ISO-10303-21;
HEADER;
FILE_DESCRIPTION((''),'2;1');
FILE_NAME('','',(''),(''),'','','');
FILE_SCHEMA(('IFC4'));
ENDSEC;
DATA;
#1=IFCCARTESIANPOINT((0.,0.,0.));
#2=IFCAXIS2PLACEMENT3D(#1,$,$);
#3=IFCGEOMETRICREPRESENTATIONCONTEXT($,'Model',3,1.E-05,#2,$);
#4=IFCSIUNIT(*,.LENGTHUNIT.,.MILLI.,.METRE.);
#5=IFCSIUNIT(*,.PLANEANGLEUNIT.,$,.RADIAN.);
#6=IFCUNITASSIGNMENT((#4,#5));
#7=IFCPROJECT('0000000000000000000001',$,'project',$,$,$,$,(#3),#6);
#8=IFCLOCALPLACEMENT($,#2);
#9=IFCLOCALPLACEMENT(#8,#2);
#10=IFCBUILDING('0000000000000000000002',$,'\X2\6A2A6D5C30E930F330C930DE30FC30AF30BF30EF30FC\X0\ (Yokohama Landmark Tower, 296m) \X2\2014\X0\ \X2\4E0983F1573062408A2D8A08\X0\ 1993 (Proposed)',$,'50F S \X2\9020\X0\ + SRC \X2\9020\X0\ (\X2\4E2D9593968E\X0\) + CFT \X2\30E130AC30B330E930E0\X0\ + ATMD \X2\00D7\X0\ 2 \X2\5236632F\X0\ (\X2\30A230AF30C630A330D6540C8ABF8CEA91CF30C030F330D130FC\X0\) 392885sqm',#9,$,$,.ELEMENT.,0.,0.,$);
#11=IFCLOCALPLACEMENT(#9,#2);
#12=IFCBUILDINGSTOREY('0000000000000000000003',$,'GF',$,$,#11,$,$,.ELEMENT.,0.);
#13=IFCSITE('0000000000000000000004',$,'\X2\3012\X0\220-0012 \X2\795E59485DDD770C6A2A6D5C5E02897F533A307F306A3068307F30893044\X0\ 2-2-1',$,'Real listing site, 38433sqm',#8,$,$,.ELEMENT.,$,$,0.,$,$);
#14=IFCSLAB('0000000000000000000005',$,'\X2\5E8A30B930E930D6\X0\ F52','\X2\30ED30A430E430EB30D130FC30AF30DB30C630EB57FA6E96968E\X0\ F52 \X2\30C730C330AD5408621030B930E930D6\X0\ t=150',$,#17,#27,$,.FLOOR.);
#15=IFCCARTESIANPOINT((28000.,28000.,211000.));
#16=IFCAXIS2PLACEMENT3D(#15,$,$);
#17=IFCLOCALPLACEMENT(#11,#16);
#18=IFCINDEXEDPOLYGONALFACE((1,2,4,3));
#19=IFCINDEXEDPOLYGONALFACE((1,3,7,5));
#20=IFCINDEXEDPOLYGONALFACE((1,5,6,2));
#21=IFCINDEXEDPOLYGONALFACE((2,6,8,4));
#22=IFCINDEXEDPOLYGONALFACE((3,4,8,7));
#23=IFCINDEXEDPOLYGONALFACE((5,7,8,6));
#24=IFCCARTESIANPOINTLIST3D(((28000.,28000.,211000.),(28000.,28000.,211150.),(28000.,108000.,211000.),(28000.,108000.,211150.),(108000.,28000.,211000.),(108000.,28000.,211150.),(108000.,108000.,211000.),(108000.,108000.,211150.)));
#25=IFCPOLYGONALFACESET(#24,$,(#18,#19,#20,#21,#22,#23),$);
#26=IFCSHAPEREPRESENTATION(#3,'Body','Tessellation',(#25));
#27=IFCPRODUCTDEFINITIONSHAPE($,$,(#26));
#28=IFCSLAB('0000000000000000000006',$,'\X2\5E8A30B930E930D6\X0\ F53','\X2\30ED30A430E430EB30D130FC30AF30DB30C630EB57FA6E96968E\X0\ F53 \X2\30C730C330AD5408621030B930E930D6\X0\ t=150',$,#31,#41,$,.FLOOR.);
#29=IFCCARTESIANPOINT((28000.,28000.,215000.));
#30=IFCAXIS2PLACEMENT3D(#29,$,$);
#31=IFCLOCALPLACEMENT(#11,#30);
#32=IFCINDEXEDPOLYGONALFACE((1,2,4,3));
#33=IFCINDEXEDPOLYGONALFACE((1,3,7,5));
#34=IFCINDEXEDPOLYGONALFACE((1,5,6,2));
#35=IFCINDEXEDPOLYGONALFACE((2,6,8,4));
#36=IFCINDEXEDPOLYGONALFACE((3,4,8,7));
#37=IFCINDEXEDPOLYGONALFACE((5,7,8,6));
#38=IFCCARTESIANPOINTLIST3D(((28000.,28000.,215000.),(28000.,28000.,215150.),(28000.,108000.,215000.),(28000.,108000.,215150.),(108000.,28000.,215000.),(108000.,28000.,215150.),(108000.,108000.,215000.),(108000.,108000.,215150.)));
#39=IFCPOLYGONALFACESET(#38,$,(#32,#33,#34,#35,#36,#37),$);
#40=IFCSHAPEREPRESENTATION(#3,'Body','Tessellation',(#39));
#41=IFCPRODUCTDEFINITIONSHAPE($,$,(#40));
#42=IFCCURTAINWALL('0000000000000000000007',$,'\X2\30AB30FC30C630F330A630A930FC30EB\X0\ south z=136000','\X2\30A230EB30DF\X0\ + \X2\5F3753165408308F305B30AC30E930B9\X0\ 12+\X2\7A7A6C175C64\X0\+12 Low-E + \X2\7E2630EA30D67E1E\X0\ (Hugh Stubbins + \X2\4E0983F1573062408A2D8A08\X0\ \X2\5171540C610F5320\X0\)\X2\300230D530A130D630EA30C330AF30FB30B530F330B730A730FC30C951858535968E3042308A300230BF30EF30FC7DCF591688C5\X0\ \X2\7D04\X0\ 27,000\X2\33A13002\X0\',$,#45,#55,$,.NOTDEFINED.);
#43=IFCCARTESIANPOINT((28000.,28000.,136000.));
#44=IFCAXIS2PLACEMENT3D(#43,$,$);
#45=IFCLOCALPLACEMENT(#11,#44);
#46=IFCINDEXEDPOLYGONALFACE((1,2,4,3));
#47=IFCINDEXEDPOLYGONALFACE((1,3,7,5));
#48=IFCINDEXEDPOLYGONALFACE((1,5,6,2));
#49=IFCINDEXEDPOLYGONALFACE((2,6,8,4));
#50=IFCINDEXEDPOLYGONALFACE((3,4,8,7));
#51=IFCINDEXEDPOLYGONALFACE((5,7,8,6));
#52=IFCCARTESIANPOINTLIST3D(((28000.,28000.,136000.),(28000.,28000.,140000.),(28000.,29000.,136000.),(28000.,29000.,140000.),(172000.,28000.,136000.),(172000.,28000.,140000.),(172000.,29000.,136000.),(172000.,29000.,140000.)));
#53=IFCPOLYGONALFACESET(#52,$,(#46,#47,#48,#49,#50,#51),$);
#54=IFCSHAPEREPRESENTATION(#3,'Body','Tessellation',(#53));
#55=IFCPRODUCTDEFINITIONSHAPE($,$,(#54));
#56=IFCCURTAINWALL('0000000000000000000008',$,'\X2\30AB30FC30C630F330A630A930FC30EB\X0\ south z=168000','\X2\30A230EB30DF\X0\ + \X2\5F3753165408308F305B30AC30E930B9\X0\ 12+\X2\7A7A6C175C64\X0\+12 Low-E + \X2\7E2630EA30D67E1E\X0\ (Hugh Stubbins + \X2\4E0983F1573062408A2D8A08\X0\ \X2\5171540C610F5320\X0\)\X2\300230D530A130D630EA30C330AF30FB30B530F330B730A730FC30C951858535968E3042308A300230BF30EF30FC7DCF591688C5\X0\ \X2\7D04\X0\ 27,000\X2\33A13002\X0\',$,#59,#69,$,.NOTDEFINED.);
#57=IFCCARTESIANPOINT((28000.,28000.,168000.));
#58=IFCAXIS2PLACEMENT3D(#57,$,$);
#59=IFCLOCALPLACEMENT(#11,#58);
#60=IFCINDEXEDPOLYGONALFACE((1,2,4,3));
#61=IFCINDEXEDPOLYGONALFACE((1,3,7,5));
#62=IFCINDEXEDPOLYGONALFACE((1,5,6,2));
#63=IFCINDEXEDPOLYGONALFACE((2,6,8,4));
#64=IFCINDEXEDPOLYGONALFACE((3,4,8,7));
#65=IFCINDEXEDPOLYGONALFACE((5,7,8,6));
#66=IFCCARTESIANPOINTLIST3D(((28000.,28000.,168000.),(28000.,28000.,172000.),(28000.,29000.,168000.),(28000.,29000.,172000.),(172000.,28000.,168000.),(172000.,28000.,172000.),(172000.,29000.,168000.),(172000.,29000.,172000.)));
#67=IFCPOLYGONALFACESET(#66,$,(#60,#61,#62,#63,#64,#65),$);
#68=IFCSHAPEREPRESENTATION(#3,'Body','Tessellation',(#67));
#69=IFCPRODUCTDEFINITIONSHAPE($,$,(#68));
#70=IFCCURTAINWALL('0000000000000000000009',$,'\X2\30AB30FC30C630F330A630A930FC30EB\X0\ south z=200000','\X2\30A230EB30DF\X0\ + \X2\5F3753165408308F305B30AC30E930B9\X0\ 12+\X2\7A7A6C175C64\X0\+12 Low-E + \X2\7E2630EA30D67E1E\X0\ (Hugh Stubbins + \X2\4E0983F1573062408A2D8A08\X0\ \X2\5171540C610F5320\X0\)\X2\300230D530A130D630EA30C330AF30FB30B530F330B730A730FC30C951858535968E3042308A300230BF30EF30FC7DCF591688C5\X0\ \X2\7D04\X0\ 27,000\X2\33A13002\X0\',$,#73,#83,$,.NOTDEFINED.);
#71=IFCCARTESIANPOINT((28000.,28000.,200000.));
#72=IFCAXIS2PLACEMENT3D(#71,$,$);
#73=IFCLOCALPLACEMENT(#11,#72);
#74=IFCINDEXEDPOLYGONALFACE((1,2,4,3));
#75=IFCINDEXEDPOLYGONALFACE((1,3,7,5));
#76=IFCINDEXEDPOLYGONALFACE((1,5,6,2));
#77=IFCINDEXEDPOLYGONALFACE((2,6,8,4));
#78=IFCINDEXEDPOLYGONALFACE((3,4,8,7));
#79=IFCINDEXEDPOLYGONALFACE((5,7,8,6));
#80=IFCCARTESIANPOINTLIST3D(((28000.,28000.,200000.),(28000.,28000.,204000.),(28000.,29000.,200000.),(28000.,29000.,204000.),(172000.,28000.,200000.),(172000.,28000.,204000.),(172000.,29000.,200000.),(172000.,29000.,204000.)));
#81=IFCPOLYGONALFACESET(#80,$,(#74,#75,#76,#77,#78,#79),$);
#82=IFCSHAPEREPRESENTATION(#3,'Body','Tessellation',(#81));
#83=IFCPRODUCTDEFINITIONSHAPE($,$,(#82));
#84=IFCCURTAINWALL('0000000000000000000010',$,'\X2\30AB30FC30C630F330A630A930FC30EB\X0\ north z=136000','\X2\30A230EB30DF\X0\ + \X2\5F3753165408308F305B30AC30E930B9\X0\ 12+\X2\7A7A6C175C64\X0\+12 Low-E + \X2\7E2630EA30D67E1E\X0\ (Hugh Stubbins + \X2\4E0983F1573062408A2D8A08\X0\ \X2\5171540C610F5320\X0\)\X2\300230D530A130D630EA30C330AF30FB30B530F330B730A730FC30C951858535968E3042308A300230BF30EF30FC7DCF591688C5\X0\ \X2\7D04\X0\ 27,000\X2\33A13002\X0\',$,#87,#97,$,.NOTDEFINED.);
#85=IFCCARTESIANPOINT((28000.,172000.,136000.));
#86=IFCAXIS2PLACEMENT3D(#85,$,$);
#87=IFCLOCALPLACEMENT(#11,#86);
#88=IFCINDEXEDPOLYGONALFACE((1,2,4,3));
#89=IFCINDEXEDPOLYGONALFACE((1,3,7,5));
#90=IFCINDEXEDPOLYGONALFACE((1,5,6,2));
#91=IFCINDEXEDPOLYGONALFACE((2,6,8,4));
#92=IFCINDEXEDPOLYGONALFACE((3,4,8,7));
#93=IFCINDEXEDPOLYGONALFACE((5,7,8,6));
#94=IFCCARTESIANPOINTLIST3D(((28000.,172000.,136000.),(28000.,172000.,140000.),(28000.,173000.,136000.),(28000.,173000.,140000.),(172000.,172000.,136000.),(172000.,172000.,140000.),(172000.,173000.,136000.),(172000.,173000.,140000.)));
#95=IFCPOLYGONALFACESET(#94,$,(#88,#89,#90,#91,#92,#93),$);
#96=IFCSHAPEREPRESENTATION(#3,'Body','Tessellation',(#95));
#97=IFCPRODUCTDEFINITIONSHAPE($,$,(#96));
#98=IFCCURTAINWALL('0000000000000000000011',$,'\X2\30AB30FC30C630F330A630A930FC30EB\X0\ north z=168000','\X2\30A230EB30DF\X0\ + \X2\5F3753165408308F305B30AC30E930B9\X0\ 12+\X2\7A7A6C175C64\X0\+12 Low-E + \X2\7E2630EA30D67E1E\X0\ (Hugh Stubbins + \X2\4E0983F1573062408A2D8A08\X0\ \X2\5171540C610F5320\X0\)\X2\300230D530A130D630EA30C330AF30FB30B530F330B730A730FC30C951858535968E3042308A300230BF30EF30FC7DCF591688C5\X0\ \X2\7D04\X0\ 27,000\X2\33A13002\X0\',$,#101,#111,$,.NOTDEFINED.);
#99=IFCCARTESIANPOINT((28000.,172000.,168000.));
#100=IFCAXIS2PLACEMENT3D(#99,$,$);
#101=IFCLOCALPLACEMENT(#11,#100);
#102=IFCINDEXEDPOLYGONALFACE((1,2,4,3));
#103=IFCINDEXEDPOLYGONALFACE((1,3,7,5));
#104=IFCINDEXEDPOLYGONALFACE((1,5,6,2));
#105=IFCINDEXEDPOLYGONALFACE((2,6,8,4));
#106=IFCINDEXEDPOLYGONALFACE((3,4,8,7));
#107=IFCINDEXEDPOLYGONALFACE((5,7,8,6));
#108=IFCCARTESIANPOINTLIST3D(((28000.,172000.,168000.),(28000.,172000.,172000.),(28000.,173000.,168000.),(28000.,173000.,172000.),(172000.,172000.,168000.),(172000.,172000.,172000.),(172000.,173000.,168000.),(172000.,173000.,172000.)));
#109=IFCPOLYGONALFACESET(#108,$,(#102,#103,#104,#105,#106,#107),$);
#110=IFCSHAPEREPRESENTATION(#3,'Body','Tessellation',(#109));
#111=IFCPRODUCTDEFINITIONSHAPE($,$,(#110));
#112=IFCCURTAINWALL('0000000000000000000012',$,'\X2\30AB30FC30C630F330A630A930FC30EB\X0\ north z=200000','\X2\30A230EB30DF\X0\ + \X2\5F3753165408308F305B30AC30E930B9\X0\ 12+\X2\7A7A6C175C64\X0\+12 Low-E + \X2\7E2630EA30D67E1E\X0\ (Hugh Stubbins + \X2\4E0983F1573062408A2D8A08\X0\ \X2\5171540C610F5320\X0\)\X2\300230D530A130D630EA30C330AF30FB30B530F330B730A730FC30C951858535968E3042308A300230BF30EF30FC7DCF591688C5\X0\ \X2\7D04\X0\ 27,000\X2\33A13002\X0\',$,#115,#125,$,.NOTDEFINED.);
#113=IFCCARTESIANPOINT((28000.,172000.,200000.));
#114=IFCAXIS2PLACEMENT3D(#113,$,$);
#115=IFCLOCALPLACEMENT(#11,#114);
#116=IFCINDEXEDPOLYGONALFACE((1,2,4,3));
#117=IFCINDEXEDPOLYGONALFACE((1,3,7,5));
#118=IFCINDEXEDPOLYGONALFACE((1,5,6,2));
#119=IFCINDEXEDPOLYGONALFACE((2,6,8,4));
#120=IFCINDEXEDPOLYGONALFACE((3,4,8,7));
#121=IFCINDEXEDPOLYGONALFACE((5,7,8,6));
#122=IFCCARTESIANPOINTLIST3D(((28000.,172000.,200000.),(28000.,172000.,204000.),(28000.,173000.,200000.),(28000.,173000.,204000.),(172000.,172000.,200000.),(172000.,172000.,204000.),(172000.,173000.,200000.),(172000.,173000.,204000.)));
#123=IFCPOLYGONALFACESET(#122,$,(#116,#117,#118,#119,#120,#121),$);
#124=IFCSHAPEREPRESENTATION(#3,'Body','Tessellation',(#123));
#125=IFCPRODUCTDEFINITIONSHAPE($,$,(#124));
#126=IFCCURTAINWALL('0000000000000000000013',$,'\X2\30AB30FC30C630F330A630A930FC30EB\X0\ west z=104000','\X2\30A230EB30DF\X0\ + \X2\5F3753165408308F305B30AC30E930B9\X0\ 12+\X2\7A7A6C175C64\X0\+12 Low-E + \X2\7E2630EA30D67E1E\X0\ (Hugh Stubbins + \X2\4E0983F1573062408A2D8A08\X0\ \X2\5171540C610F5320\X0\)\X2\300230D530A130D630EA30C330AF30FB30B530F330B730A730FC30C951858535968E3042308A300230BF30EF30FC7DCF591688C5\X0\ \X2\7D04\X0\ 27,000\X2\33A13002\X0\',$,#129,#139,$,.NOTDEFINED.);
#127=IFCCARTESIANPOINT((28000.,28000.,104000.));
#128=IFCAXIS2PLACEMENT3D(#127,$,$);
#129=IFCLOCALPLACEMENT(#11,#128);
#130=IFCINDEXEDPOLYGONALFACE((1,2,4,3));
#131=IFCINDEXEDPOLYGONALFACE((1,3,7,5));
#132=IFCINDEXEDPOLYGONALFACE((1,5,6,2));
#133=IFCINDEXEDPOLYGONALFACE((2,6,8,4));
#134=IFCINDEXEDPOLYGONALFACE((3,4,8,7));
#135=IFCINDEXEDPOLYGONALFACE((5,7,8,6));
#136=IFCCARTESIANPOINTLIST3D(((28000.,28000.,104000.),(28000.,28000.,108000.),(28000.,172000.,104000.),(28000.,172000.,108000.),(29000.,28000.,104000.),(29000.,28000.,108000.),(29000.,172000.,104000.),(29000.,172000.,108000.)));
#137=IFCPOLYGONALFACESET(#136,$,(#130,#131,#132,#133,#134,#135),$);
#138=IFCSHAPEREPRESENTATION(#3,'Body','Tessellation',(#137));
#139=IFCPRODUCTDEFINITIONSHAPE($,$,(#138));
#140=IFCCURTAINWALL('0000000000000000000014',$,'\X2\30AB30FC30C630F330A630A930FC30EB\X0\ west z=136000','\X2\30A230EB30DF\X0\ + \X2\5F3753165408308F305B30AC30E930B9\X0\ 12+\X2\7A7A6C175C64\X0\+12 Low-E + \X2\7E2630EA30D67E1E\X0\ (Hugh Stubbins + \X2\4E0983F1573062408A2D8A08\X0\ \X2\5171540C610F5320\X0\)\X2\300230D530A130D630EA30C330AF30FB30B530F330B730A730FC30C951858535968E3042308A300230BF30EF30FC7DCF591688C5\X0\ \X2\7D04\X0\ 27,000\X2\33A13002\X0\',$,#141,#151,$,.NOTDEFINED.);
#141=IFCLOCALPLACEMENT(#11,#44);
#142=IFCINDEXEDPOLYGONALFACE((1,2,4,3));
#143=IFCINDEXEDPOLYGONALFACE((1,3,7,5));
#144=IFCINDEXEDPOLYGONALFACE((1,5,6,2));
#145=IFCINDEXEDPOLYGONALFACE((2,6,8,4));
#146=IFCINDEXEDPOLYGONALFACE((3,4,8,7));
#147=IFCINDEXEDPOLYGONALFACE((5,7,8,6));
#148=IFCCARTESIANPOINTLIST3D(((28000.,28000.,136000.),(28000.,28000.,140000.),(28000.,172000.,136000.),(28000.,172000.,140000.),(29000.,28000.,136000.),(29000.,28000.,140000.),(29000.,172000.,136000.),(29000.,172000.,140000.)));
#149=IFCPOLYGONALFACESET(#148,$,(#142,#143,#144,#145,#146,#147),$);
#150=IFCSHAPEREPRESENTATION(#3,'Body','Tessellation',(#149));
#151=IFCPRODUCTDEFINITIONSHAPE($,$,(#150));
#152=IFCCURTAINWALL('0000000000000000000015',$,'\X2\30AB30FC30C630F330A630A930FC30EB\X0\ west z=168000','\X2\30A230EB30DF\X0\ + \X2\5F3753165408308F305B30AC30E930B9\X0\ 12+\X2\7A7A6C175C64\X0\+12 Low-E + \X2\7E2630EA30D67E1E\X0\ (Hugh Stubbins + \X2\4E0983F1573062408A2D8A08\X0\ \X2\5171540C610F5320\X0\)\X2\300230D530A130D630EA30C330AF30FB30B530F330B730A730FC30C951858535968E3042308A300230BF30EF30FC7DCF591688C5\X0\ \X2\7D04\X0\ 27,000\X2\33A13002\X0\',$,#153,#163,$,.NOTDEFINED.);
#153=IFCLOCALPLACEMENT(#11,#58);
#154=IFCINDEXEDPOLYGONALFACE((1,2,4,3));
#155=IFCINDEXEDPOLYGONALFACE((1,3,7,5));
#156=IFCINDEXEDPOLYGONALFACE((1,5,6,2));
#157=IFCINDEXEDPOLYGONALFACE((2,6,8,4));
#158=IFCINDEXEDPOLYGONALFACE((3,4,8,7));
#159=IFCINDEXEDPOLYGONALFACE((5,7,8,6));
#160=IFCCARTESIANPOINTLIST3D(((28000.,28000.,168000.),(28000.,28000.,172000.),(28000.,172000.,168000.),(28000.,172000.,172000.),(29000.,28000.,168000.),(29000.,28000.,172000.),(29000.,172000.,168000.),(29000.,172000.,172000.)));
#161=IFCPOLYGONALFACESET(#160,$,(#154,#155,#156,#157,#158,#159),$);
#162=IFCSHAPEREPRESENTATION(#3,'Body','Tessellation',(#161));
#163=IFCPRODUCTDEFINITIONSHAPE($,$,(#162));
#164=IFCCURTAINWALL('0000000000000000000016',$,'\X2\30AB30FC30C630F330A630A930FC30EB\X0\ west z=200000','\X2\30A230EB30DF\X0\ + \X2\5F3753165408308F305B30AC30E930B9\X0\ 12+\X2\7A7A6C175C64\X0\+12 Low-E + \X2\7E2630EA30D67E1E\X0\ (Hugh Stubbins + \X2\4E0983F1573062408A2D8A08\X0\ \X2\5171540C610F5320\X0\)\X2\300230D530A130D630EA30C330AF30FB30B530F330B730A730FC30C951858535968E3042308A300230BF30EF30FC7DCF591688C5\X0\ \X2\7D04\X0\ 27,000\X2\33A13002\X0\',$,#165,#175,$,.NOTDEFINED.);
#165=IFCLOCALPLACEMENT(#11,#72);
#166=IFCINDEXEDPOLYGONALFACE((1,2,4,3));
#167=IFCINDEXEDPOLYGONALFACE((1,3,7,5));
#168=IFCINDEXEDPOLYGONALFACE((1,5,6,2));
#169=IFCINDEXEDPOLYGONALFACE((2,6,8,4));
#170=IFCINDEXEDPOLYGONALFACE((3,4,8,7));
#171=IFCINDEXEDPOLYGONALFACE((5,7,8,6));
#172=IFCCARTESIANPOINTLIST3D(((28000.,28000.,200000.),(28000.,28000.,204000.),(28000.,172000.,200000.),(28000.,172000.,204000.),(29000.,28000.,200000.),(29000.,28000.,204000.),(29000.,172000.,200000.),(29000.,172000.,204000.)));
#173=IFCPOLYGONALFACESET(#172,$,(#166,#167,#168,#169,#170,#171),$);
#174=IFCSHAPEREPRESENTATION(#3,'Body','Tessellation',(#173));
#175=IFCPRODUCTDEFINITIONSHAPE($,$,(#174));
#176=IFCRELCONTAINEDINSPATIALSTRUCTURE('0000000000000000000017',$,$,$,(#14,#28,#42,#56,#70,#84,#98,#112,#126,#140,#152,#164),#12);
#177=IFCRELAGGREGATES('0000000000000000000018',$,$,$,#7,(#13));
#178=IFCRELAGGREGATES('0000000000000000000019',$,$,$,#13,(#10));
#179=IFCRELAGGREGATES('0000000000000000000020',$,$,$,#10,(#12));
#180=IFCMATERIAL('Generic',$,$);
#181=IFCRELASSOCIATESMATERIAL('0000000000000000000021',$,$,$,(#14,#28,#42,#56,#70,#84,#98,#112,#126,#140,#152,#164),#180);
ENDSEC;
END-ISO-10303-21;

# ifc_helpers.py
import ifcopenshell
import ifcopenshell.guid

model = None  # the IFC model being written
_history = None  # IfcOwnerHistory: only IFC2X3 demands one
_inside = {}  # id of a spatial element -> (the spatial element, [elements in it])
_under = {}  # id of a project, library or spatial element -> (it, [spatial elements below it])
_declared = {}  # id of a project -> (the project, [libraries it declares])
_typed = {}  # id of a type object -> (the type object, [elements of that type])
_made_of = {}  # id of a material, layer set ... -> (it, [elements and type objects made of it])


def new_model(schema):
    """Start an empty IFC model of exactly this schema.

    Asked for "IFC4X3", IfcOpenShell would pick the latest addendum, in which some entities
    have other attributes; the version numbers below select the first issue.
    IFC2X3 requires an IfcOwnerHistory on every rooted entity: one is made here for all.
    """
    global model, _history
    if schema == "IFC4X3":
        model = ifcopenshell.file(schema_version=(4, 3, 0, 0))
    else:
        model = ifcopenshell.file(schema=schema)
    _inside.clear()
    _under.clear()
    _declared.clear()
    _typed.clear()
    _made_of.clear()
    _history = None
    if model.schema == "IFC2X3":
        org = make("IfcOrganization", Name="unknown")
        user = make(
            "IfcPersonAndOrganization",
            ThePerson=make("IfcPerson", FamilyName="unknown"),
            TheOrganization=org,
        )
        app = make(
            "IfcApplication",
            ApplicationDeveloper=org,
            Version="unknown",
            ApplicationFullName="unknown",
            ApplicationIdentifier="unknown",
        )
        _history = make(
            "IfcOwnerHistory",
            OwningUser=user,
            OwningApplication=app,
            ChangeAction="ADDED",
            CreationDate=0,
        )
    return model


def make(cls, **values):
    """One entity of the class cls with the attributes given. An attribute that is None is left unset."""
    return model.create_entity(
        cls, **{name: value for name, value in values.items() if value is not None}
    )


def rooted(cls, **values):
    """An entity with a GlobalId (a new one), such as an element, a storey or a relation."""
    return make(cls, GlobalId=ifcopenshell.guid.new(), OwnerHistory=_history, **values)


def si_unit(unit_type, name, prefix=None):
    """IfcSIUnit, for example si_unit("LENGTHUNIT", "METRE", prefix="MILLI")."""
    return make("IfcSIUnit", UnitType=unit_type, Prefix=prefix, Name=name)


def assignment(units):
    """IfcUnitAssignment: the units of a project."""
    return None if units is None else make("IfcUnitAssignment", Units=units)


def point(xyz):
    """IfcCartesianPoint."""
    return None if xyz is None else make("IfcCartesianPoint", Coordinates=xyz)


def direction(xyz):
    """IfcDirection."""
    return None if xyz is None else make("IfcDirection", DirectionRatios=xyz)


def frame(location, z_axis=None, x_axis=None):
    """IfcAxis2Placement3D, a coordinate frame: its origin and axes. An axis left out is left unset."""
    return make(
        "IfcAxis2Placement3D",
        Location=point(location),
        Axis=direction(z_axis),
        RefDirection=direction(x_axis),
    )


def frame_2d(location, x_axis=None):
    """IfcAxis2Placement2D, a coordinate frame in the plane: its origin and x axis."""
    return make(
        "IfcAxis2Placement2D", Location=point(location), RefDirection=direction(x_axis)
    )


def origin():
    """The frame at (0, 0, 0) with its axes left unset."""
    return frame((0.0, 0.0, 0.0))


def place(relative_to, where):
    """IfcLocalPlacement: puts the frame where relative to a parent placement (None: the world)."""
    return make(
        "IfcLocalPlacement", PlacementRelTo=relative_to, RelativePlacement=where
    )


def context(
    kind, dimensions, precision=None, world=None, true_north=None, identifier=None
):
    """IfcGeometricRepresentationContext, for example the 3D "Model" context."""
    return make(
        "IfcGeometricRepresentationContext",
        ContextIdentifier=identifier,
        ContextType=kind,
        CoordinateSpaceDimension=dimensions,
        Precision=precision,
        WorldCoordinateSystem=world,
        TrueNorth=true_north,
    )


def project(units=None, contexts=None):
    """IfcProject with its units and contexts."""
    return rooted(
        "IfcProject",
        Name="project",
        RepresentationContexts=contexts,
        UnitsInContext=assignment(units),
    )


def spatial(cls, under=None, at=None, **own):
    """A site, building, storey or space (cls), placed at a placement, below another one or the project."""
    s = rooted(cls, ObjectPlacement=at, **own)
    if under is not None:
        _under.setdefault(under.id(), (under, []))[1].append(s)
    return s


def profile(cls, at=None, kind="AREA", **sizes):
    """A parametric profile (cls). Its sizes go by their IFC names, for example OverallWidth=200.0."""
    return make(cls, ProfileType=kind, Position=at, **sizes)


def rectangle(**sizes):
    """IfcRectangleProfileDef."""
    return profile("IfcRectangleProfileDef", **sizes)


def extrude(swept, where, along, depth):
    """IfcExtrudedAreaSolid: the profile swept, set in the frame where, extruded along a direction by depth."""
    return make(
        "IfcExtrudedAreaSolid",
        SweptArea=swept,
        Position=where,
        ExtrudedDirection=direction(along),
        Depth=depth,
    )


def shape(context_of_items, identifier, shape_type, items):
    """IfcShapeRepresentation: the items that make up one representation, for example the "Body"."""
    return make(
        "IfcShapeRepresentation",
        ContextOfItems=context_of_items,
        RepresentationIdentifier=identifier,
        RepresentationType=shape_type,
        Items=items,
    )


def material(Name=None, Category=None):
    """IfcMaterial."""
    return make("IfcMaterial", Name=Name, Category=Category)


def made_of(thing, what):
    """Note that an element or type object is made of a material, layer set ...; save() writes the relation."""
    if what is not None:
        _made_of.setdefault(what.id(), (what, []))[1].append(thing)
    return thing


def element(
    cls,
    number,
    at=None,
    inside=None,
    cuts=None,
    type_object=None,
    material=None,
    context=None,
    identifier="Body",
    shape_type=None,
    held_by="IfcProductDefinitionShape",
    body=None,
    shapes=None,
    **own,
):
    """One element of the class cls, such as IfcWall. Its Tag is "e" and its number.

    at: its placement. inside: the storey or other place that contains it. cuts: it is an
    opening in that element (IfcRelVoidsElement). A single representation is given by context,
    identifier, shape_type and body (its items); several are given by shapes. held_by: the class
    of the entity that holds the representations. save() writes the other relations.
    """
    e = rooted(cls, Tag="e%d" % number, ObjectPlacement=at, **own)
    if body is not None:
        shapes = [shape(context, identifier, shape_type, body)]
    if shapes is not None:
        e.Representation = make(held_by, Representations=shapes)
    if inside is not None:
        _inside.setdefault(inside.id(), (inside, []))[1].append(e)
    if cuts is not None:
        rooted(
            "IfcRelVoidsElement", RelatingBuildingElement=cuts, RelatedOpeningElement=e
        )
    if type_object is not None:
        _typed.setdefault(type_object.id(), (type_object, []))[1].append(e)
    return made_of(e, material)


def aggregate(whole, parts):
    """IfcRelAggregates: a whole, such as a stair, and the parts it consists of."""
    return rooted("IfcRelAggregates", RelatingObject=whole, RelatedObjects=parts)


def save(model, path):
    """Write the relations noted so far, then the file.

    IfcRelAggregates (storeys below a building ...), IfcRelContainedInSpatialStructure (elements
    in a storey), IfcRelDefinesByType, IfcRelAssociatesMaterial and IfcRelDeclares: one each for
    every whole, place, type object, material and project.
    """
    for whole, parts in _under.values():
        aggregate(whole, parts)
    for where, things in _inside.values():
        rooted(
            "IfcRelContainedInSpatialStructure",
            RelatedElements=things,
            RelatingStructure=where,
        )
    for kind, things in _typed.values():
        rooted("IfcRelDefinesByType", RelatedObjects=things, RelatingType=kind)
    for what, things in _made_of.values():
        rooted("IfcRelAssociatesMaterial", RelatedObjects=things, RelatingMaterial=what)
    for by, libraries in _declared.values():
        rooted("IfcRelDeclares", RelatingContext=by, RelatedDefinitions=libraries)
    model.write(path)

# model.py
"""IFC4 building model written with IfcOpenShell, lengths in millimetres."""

from ifc_helpers import new_model, si_unit, frame, frame_2d, origin, place, context, project, spatial, rectangle, extrude, material, element, save


model = new_model("IFC4")

# Units and contexts
model_context = context("Model", 3, precision=1e-05, world=origin())
ifc_project = project(units=[si_unit("LENGTHUNIT", "METRE", prefix="MILLI"), si_unit("PLANEANGLEUNIT", "RADIAN")], contexts=[model_context])

# Site, building, storey
site_placement = place(None, origin())
site = spatial("IfcSite", under=ifc_project, at=site_placement, Name="〒220-0012 神奈川県横浜市西区みなとみらい 2-2-1", ObjectType="Real listing site, 38433sqm", CompositionType="ELEMENT", RefElevation=0.0)
building_placement = place(site_placement, origin())
building = spatial("IfcBuilding", under=site, at=building_placement, Name="横浜ランドマークタワー (Yokohama Landmark Tower, 296m) — 三菱地所設計 1993 (Proposed)", ObjectType="50F S 造 + SRC 造 (中間階) + CFT メガコラム + ATMD × 2 制振 (アクティブ同調質量ダンパー) 392885sqm", CompositionType="ELEMENT", ElevationOfRefHeight=0.0, ElevationOfTerrain=0.0)
storey_placement = place(building_placement, origin())
storey = spatial("IfcBuildingStorey", under=building, at=storey_placement, Name="GF", CompositionType="ELEMENT", Elevation=0.0)

# Slabs
ifc_material_1 = material(Name="Generic")
slab_1_placement = place(storey_placement, frame((28000.0, 28000.0, 211000.0)))
element("IfcSlab", 1, at=slab_1_placement, inside=storey, material=ifc_material_1, Name="床スラブ F52", Description="ロイヤルパークホテル基準階 F52 デッキ合成スラブ t=150", PredefinedType="FLOOR", context=model_context, shape_type="SweptSolid", body=[
    extrude(rectangle(XDim=80000.0, YDim=80000.0, at=frame_2d((40000.0, 40000.0))), frame((28000.0, 28000.0, 211000.0)), (0.0, 0.0, 1.0), 150.0),
])
slab_2_placement = place(storey_placement, frame((28000.0, 28000.0, 215000.0)))
element("IfcSlab", 2, at=slab_2_placement, inside=storey, material=ifc_material_1, Name="床スラブ F53", Description="ロイヤルパークホテル基準階 F53 デッキ合成スラブ t=150", PredefinedType="FLOOR", context=model_context, shape_type="SweptSolid", body=[
    extrude(rectangle(XDim=80000.0, YDim=80000.0, at=frame_2d((40000.0, 40000.0))), frame((28000.0, 28000.0, 215000.0)), (0.0, 0.0, 1.0), 150.0),
])

# Curtain walls
curtain_wall_1_placement = place(storey_placement, frame((28000.0, 28000.0, 136000.0)))
element("IfcCurtainWall", 3, at=curtain_wall_1_placement, inside=storey, material=ifc_material_1, Name="カーテンウォール south z=136000", Description="アルミ + 強化合わせガラス 12+空気層+12 Low-E + 縦リブ縞 (Hugh Stubbins + 三菱地所設計 共同意匠)。ファブリック・サンシェード内蔵階あり。タワー総外装 約 27,000㎡。", PredefinedType="NOTDEFINED", context=model_context, shape_type="SweptSolid", body=[
    extrude(rectangle(XDim=144000.0, YDim=1000.0, at=frame_2d((72000.0, 500.0))), frame((28000.0, 28000.0, 136000.0)), (0.0, 0.0, 1.0), 4000.0),
])
curtain_wall_2_placement = place(storey_placement, frame((28000.0, 28000.0, 168000.0)))
element("IfcCurtainWall", 4, at=curtain_wall_2_placement, inside=storey, material=ifc_material_1, Name="カーテンウォール south z=168000", Description="アルミ + 強化合わせガラス 12+空気層+12 Low-E + 縦リブ縞 (Hugh Stubbins + 三菱地所設計 共同意匠)。ファブリック・サンシェード内蔵階あり。タワー総外装 約 27,000㎡。", PredefinedType="NOTDEFINED", context=model_context, shape_type="SweptSolid", body=[
    extrude(rectangle(XDim=144000.0, YDim=1000.0, at=frame_2d((72000.0, 500.0))), frame((28000.0, 28000.0, 168000.0)), (0.0, 0.0, 1.0), 4000.0),
])
curtain_wall_3_placement = place(storey_placement, frame((28000.0, 28000.0, 200000.0)))
element("IfcCurtainWall", 5, at=curtain_wall_3_placement, inside=storey, material=ifc_material_1, Name="カーテンウォール south z=200000", Description="アルミ + 強化合わせガラス 12+空気層+12 Low-E + 縦リブ縞 (Hugh Stubbins + 三菱地所設計 共同意匠)。ファブリック・サンシェード内蔵階あり。タワー総外装 約 27,000㎡。", PredefinedType="NOTDEFINED", context=model_context, shape_type="SweptSolid", body=[
    extrude(rectangle(XDim=144000.0, YDim=1000.0, at=frame_2d((72000.0, 500.0))), frame((28000.0, 28000.0, 200000.0)), (0.0, 0.0, 1.0), 4000.0),
])
curtain_wall_4_placement = place(storey_placement, frame((28000.0, 172000.0, 136000.0)))
element("IfcCurtainWall", 6, at=curtain_wall_4_placement, inside=storey, material=ifc_material_1, Name="カーテンウォール north z=136000", Description="アルミ + 強化合わせガラス 12+空気層+12 Low-E + 縦リブ縞 (Hugh Stubbins + 三菱地所設計 共同意匠)。ファブリック・サンシェード内蔵階あり。タワー総外装 約 27,000㎡。", PredefinedType="NOTDEFINED", context=model_context, shape_type="SweptSolid", body=[
    extrude(rectangle(XDim=144000.0, YDim=1000.0, at=frame_2d((72000.0, 500.0))), frame((28000.0, 172000.0, 136000.0)), (0.0, 0.0, 1.0), 4000.0),
])
curtain_wall_5_placement = place(storey_placement, frame((28000.0, 172000.0, 168000.0)))
element("IfcCurtainWall", 7, at=curtain_wall_5_placement, inside=storey, material=ifc_material_1, Name="カーテンウォール north z=168000", Description="アルミ + 強化合わせガラス 12+空気層+12 Low-E + 縦リブ縞 (Hugh Stubbins + 三菱地所設計 共同意匠)。ファブリック・サンシェード内蔵階あり。タワー総外装 約 27,000㎡。", PredefinedType="NOTDEFINED", context=model_context, shape_type="SweptSolid", body=[
    extrude(rectangle(XDim=144000.0, YDim=1000.0, at=frame_2d((72000.0, 500.0))), frame((28000.0, 172000.0, 168000.0)), (0.0, 0.0, 1.0), 4000.0),
])
curtain_wall_6_placement = place(storey_placement, frame((28000.0, 172000.0, 200000.0)))
element("IfcCurtainWall", 8, at=curtain_wall_6_placement, inside=storey, material=ifc_material_1, Name="カーテンウォール north z=200000", Description="アルミ + 強化合わせガラス 12+空気層+12 Low-E + 縦リブ縞 (Hugh Stubbins + 三菱地所設計 共同意匠)。ファブリック・サンシェード内蔵階あり。タワー総外装 約 27,000㎡。", PredefinedType="NOTDEFINED", context=model_context, shape_type="SweptSolid", body=[
    extrude(rectangle(XDim=144000.0, YDim=1000.0, at=frame_2d((72000.0, 500.0))), frame((28000.0, 172000.0, 200000.0)), (0.0, 0.0, 1.0), 4000.0),
])
curtain_wall_7_placement = place(storey_placement, frame((28000.0, 28000.0, 104000.0)))
element("IfcCurtainWall", 9, at=curtain_wall_7_placement, inside=storey, material=ifc_material_1, Name="カーテンウォール west z=104000", Description="アルミ + 強化合わせガラス 12+空気層+12 Low-E + 縦リブ縞 (Hugh Stubbins + 三菱地所設計 共同意匠)。ファブリック・サンシェード内蔵階あり。タワー総外装 約 27,000㎡。", PredefinedType="NOTDEFINED", context=model_context, shape_type="SweptSolid", body=[
    extrude(rectangle(XDim=1000.0, YDim=144000.0, at=frame_2d((500.0, 72000.0))), frame((28000.0, 28000.0, 104000.0)), (0.0, 0.0, 1.0), 4000.0),
])
curtain_wall_8_placement = place(storey_placement, frame((28000.0, 28000.0, 136000.0)))
element("IfcCurtainWall", 10, at=curtain_wall_8_placement, inside=storey, material=ifc_material_1, Name="カーテンウォール west z=136000", Description="アルミ + 強化合わせガラス 12+空気層+12 Low-E + 縦リブ縞 (Hugh Stubbins + 三菱地所設計 共同意匠)。ファブリック・サンシェード内蔵階あり。タワー総外装 約 27,000㎡。", PredefinedType="NOTDEFINED", context=model_context, shape_type="SweptSolid", body=[
    extrude(rectangle(XDim=1000.0, YDim=144000.0, at=frame_2d((500.0, 72000.0))), frame((28000.0, 28000.0, 136000.0)), (0.0, 0.0, 1.0), 4000.0),
])
curtain_wall_9_placement = place(storey_placement, frame((28000.0, 28000.0, 168000.0)))
element("IfcCurtainWall", 11, at=curtain_wall_9_placement, inside=storey, material=ifc_material_1, Name="カーテンウォール west z=168000", Description="アルミ + 強化合わせガラス 12+空気層+12 Low-E + 縦リブ縞 (Hugh Stubbins + 三菱地所設計 共同意匠)。ファブリック・サンシェード内蔵階あり。タワー総外装 約 27,000㎡。", PredefinedType="NOTDEFINED", context=model_context, shape_type="SweptSolid", body=[
    extrude(rectangle(XDim=1000.0, YDim=144000.0, at=frame_2d((500.0, 72000.0))), frame((28000.0, 28000.0, 168000.0)), (0.0, 0.0, 1.0), 4000.0),
])
curtain_wall_10_placement = place(storey_placement, frame((28000.0, 28000.0, 200000.0)))
element("IfcCurtainWall", 12, at=curtain_wall_10_placement, inside=storey, material=ifc_material_1, Name="カーテンウォール west z=200000", Description="アルミ + 強化合わせガラス 12+空気層+12 Low-E + 縦リブ縞 (Hugh Stubbins + 三菱地所設計 共同意匠)。ファブリック・サンシェード内蔵階あり。タワー総外装 約 27,000㎡。", PredefinedType="NOTDEFINED", context=model_context, shape_type="SweptSolid", body=[
    extrude(rectangle(XDim=1000.0, YDim=144000.0, at=frame_2d((500.0, 72000.0))), frame((28000.0, 28000.0, 200000.0)), (0.0, 0.0, 1.0), 4000.0),
])

save(model, "model.ifc")
